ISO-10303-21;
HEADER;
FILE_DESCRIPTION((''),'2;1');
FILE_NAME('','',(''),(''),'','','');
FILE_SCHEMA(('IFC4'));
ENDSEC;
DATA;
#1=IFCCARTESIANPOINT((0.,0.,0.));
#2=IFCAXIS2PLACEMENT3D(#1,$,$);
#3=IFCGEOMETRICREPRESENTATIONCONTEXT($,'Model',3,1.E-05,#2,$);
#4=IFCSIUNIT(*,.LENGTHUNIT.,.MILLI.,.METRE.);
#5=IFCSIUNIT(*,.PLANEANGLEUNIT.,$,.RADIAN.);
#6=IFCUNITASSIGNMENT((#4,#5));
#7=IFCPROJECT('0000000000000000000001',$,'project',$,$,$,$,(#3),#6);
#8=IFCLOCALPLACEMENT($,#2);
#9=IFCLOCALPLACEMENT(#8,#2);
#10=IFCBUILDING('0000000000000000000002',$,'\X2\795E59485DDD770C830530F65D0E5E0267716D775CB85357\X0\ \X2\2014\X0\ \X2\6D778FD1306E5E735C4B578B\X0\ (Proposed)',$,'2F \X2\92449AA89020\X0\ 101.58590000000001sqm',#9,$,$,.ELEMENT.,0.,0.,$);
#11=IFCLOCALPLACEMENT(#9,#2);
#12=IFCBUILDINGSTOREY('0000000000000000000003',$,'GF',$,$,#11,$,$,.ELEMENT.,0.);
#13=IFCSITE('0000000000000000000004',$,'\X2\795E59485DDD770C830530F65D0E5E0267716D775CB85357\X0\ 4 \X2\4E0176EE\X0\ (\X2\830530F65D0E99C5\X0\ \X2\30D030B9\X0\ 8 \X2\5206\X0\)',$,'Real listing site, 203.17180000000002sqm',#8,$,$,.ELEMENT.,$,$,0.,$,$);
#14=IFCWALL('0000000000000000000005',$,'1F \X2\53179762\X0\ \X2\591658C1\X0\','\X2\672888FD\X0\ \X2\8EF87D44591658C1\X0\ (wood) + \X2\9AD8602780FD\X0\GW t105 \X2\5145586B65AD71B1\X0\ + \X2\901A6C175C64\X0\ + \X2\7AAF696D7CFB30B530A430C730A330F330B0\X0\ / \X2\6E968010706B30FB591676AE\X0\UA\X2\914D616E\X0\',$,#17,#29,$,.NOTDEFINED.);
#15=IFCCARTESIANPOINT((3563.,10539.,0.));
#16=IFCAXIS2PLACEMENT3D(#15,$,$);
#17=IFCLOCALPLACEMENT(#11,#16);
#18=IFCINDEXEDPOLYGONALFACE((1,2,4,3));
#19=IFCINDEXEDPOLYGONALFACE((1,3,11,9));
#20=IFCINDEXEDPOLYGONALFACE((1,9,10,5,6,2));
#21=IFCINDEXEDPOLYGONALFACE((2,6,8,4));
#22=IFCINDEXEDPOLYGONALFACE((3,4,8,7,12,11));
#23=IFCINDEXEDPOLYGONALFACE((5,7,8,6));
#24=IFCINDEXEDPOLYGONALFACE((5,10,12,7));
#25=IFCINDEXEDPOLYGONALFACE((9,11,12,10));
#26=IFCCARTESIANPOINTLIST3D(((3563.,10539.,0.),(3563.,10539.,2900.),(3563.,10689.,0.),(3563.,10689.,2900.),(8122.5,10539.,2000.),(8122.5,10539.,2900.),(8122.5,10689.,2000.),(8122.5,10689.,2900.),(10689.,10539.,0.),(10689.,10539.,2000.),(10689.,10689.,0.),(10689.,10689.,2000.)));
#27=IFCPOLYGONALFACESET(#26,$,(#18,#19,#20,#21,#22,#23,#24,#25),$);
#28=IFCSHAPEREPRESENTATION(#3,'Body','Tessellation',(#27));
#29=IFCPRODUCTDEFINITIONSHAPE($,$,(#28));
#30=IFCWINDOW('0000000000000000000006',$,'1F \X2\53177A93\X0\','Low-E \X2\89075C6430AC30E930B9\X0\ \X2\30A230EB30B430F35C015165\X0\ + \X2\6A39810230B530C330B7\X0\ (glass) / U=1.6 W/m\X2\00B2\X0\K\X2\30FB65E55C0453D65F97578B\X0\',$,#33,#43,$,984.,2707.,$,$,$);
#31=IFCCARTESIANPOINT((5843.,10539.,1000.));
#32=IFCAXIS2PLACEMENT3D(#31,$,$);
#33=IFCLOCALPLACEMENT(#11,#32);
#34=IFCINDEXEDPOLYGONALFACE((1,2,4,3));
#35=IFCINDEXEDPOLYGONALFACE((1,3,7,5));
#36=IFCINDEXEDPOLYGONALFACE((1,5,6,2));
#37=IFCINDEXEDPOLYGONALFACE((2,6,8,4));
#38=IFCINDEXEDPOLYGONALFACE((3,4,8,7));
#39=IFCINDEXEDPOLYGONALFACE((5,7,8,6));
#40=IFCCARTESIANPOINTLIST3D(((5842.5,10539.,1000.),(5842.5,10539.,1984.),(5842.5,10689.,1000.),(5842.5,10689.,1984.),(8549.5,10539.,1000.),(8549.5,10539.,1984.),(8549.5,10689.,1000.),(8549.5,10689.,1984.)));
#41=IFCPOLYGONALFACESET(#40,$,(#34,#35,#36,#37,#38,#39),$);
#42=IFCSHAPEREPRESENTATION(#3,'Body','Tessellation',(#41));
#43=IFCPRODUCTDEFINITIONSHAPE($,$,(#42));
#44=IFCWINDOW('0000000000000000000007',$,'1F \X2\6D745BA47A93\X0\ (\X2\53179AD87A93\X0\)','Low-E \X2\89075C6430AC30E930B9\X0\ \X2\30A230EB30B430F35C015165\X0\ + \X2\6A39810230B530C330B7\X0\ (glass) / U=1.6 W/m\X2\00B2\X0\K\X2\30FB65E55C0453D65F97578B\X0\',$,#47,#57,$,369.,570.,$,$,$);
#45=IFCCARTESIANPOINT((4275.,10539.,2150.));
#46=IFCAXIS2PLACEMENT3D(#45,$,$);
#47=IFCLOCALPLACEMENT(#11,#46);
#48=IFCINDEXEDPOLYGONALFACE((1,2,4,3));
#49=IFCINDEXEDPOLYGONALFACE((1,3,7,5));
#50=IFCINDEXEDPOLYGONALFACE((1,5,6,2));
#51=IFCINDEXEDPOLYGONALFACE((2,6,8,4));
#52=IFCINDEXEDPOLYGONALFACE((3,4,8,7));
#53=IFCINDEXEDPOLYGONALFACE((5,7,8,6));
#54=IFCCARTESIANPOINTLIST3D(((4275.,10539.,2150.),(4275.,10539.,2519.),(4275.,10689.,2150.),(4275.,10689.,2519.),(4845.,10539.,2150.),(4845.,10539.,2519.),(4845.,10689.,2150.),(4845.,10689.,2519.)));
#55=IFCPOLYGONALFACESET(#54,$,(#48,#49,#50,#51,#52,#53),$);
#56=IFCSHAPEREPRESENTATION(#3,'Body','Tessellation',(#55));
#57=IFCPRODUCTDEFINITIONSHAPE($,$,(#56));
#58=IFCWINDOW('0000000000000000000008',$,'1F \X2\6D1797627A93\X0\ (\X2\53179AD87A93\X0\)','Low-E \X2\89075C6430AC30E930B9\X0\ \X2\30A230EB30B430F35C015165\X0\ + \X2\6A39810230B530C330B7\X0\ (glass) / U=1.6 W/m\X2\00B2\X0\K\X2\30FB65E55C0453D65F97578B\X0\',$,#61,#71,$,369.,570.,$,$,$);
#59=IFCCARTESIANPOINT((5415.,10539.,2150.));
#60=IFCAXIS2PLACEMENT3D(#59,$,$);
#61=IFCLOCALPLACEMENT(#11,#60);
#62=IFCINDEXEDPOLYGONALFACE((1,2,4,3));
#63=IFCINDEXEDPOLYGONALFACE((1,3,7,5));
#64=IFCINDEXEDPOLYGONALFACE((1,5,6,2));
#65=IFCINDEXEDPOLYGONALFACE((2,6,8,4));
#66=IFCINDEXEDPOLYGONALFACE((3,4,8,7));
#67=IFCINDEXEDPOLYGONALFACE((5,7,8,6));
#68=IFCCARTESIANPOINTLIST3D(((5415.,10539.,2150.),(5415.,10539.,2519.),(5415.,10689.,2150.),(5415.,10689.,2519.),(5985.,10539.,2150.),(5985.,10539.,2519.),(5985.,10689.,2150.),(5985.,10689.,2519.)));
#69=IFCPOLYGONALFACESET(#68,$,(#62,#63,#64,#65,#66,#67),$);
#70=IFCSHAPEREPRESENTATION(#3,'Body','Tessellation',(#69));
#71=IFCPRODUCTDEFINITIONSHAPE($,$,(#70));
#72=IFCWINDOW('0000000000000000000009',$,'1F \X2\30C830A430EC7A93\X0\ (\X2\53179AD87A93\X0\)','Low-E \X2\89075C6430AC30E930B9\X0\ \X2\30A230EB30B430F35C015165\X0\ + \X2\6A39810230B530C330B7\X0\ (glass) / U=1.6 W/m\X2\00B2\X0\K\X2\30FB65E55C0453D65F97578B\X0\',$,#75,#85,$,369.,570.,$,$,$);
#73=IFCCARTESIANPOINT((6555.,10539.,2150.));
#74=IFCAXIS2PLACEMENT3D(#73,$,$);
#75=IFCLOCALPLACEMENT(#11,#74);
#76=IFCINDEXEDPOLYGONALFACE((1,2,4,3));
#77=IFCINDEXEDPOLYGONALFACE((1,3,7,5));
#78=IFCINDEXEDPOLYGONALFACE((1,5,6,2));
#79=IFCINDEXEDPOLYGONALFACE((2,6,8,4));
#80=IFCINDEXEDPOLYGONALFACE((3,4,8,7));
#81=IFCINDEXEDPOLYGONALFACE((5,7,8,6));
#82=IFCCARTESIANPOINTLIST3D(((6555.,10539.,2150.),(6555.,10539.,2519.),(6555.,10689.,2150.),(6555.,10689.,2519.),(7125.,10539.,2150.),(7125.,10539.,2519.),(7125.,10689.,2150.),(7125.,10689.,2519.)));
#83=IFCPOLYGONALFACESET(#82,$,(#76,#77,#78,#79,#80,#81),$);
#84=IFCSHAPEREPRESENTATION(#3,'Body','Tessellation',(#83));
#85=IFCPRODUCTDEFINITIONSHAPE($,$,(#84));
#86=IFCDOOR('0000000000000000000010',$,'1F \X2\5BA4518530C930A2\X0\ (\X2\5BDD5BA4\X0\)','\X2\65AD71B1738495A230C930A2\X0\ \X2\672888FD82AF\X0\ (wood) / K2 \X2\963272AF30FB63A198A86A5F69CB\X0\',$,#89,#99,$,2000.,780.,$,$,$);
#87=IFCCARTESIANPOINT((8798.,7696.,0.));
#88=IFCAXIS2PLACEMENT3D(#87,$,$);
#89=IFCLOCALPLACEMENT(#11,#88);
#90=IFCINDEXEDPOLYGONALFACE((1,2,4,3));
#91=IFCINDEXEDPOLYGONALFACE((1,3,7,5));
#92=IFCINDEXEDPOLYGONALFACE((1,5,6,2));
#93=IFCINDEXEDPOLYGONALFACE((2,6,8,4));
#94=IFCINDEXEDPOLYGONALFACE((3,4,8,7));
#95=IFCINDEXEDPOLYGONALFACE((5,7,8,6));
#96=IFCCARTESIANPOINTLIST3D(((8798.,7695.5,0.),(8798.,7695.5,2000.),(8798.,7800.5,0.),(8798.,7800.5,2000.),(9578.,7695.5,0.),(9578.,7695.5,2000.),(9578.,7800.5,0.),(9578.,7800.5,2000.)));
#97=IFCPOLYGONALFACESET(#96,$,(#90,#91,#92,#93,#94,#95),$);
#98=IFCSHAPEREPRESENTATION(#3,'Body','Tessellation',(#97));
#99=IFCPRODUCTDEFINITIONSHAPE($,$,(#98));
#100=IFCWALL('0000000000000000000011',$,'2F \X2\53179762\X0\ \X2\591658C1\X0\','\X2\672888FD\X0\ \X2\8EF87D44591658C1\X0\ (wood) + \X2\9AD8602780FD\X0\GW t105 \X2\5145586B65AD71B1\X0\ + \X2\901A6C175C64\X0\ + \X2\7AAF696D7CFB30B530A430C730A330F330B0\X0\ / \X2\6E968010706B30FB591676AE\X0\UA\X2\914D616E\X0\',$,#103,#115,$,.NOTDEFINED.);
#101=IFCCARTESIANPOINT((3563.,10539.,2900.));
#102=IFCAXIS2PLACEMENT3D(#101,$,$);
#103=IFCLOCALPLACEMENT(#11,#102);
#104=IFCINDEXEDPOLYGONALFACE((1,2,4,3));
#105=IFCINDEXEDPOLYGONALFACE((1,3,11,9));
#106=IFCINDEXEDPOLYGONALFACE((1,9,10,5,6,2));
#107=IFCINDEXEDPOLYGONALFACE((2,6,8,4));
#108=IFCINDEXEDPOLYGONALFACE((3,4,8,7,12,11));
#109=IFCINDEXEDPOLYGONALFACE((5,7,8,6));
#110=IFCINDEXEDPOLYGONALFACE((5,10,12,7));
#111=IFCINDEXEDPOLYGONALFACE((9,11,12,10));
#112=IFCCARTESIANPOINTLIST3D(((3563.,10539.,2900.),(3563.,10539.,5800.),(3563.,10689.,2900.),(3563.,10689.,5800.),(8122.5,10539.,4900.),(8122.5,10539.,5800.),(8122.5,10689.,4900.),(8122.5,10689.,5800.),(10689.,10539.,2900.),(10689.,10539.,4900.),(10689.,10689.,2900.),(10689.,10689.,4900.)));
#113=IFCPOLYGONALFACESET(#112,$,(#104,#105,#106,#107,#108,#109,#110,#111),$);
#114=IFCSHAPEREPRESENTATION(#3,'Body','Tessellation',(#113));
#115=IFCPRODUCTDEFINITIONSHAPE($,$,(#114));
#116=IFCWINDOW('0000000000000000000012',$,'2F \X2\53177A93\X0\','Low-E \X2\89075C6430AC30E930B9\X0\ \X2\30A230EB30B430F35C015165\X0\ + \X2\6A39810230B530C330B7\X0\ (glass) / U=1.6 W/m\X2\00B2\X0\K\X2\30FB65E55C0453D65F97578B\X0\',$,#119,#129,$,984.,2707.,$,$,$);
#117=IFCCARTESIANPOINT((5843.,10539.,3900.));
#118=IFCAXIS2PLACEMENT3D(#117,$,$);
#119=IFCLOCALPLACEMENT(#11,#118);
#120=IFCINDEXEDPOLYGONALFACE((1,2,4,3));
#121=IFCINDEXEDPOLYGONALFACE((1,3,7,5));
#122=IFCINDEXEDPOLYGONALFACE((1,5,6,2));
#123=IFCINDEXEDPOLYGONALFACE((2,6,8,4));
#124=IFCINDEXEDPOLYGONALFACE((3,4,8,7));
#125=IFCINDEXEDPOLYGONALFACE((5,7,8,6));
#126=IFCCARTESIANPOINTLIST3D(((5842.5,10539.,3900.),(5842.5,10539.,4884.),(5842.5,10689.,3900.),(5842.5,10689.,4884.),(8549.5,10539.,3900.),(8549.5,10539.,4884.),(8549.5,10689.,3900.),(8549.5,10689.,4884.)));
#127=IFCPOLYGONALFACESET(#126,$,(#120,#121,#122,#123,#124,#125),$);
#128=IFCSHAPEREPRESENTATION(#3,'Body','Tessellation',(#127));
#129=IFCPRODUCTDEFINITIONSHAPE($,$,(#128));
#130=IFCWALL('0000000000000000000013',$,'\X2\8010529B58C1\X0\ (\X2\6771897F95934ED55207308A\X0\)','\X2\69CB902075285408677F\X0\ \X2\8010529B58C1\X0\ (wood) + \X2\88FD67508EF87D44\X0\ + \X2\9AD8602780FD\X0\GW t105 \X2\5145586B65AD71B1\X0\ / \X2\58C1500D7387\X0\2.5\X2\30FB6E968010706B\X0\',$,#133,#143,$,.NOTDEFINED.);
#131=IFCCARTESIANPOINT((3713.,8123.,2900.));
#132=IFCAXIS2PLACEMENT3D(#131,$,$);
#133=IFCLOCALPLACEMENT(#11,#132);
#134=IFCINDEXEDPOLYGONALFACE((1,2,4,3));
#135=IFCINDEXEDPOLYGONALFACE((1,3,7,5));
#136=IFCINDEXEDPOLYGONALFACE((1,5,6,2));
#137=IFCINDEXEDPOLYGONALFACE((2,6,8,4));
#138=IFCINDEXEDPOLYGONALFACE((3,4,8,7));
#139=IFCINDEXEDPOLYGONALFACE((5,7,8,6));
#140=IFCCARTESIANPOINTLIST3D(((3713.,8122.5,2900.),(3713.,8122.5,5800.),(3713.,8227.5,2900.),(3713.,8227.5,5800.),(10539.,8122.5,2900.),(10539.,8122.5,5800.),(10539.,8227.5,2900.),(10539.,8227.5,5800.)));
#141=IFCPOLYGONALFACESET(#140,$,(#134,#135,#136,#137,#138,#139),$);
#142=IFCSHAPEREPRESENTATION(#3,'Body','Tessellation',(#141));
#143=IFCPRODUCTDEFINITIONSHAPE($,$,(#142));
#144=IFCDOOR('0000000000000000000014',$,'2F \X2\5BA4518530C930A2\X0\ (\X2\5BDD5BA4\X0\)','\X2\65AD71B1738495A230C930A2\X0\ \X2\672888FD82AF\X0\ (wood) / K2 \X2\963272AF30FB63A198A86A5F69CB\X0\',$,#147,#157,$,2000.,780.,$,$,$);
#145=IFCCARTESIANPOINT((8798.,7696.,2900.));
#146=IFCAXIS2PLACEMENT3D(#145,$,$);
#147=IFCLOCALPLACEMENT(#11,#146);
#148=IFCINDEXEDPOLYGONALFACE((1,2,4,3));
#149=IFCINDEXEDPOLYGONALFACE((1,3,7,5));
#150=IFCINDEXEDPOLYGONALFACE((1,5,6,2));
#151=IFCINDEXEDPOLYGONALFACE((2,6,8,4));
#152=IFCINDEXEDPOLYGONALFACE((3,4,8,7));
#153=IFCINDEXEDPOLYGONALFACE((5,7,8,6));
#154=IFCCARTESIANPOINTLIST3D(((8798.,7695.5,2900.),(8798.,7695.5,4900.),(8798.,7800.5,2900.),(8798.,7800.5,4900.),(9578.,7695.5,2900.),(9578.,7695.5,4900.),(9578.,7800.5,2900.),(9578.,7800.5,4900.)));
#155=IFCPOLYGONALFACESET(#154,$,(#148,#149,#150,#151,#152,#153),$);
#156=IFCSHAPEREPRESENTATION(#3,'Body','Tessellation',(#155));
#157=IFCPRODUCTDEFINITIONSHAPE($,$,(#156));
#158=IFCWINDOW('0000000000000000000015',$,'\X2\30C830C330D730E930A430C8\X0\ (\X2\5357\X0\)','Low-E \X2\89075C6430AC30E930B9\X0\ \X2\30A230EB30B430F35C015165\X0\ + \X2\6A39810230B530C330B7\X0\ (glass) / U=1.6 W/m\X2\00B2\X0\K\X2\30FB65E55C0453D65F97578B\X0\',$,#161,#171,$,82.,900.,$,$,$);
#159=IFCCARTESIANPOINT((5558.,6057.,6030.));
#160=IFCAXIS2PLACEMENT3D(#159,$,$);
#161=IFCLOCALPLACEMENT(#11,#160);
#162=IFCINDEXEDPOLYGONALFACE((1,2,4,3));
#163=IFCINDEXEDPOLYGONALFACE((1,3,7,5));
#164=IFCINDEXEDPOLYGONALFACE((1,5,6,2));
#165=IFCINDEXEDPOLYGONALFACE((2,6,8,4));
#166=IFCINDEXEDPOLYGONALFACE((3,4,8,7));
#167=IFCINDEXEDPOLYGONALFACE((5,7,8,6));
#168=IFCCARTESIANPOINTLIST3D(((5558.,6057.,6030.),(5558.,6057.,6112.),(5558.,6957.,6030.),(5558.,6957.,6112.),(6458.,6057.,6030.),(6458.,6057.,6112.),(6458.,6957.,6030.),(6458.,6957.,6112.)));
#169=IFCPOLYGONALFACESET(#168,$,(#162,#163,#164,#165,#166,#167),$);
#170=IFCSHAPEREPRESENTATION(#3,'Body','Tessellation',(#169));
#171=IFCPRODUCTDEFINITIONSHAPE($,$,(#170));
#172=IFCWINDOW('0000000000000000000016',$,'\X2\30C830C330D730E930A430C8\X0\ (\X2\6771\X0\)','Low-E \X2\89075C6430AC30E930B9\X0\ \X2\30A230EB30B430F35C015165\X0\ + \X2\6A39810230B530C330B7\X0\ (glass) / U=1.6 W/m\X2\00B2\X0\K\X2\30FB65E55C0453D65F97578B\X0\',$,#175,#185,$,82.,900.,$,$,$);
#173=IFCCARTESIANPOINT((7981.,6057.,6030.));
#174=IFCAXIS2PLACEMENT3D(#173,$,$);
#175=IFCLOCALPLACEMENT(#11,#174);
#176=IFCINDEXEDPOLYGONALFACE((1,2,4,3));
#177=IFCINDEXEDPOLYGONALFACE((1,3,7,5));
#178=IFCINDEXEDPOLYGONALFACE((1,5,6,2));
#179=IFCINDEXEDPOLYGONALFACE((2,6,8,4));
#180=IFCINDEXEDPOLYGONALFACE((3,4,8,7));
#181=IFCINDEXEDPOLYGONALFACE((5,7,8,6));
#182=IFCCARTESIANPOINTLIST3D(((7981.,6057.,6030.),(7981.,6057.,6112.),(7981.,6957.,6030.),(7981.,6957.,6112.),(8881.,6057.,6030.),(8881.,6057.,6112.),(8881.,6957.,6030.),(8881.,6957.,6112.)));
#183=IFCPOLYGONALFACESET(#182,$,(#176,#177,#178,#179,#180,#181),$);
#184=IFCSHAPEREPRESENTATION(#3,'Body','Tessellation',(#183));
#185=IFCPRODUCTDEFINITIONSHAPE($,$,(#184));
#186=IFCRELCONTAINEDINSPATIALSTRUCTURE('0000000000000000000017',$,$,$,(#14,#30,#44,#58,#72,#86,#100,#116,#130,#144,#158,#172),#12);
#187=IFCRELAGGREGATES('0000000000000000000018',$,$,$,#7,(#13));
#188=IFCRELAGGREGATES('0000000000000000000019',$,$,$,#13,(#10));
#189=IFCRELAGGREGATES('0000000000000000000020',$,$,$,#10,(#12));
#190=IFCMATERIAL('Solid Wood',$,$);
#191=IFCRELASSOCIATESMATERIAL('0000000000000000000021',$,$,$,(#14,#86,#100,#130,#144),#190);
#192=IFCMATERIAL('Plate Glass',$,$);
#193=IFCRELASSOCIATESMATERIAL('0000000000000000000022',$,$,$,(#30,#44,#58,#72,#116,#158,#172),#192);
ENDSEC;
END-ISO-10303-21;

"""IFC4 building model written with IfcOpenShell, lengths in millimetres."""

from ifc_helpers import new_model, si_unit, frame, frame_2d, origin, place, context, project, spatial, rectangle, extrude, material, element, fill, save


model = new_model("IFC4")

# Units and contexts
model_context = context("Model", 3, precision=1e-05, world=origin())
ifc_project = project(units=[si_unit("LENGTHUNIT", "METRE", prefix="MILLI"), si_unit("PLANEANGLEUNIT", "RADIAN")], contexts=[model_context])

# Site, building, storey
site_placement = place(None, origin())
site = spatial("IfcSite", under=ifc_project, at=site_placement, Name="神奈川県茅ヶ崎市東海岸南 4 丁目 (茅ヶ崎駅 バス 8 分)", ObjectType="Real listing site, 203.17180000000002sqm", CompositionType="ELEMENT", RefElevation=0.0)
building_placement = place(site_placement, origin())
building = spatial("IfcBuilding", under=site, at=building_placement, Name="神奈川県茅ヶ崎市東海岸南 — 海近の平屋型 (Proposed)", ObjectType="2F 鉄骨造 101.58590000000001sqm", CompositionType="ELEMENT", ElevationOfRefHeight=0.0, ElevationOfTerrain=0.0)
storey_placement = place(building_placement, origin())
storey = spatial("IfcBuildingStorey", under=building, at=storey_placement, Name="GF", CompositionType="ELEMENT", Elevation=0.0)

# Wall, openings, windows
ifc_material_1 = material(Name="Solid Wood")
wall_1_placement = place(storey_placement, frame((3563.0, 10539.0, 0.0)))
wall_1 = element("IfcWall", 1, at=wall_1_placement, inside=storey, material=ifc_material_1, Name="1F 北面 外壁", Description="木製 軸組外壁 (wood) + 高性能GW t105 充填断熱 + 通気層 + 窯業系サイディング / 準耐火・外皮UA配慮", PredefinedType="NOTDEFINED", context=model_context, shape_type="SweptSolid", body=[
    extrude(rectangle(XDim=7126.0, YDim=150.0, at=frame_2d((3563.0, 75.0))), frame((3563.0, 10539.0, 0.0)), (0.0, 0.0, 1.0), 2900.0),
])
opening_1_placement = place(storey_placement, frame((5843.0, 10539.0, 1000.0)))
opening_1 = element("IfcOpeningElement", 2, at=opening_1_placement, cuts=wall_1, PredefinedType="NOTDEFINED", context=model_context, shape_type="SweptSolid", body=[
    extrude(rectangle(XDim=2707.0, YDim=150.0, at=frame_2d((1353.0, 75.0))), frame((5843.0, 10539.0, 1000.0)), (0.0, 0.0, 1.0), 984.0),
])
opening_2_placement = place(storey_placement, frame((4275.0, 10539.0, 2150.0)))
opening_2 = element("IfcOpeningElement", 3, at=opening_2_placement, cuts=wall_1, PredefinedType="NOTDEFINED", context=model_context, shape_type="SweptSolid", body=[
    extrude(rectangle(XDim=570.0, YDim=150.0, at=frame_2d((285.0, 75.0))), frame((4275.0, 10539.0, 2150.0)), (0.0, 0.0, 1.0), 369.0),
])
opening_3_placement = place(storey_placement, frame((5415.0, 10539.0, 2150.0)))
opening_3 = element("IfcOpeningElement", 4, at=opening_3_placement, cuts=wall_1, PredefinedType="NOTDEFINED", context=model_context, shape_type="SweptSolid", body=[
    extrude(rectangle(XDim=570.0, YDim=150.0, at=frame_2d((285.0, 75.0))), frame((5415.0, 10539.0, 2150.0)), (0.0, 0.0, 1.0), 369.0),
])
opening_4_placement = place(storey_placement, frame((6555.0, 10539.0, 2150.0)))
opening_4 = element("IfcOpeningElement", 5, at=opening_4_placement, cuts=wall_1, PredefinedType="NOTDEFINED", context=model_context, shape_type="SweptSolid", body=[
    extrude(rectangle(XDim=570.0, YDim=150.0, at=frame_2d((285.0, 75.0))), frame((6555.0, 10539.0, 2150.0)), (0.0, 0.0, 1.0), 369.0),
])
ifc_material_2 = material(Name="Plate Glass")
window_1_placement = place(storey_placement, frame((5843.0, 10539.0, 1000.0)))
window_1 = element("IfcWindow", 6, at=window_1_placement, inside=storey, material=ifc_material_2, Name="1F 北窓", Description="Low-E 複層ガラス アルゴン封入 + 樹脂サッシ (glass) / U=1.6 W/m²K・日射取得型", OverallHeight=984.0, OverallWidth=2707.0, context=model_context, shape_type="SweptSolid", body=[
    extrude(rectangle(XDim=2707.0, YDim=150.0, at=frame_2d((1353.0, 75.0))), frame((5843.0, 10539.0, 1000.0)), (0.0, 0.0, 1.0), 984.0),
])
fill(opening_1, window_1)
window_2_placement = place(storey_placement, frame((4275.0, 10539.0, 2150.0)))
window_2 = element("IfcWindow", 7, at=window_2_placement, inside=storey, material=ifc_material_2, Name="1F 浴室窓 (北高窓)", Description="Low-E 複層ガラス アルゴン封入 + 樹脂サッシ (glass) / U=1.6 W/m²K・日射取得型", OverallHeight=369.0, OverallWidth=570.0, context=model_context, shape_type="SweptSolid", body=[
    extrude(rectangle(XDim=570.0, YDim=150.0, at=frame_2d((285.0, 75.0))), frame((4275.0, 10539.0, 2150.0)), (0.0, 0.0, 1.0), 369.0),
])
fill(opening_2, window_2)
window_3_placement = place(storey_placement, frame((5415.0, 10539.0, 2150.0)))
window_3 = element("IfcWindow", 8, at=window_3_placement, inside=storey, material=ifc_material_2, Name="1F 洗面窓 (北高窓)", Description="Low-E 複層ガラス アルゴン封入 + 樹脂サッシ (glass) / U=1.6 W/m²K・日射取得型", OverallHeight=369.0, OverallWidth=570.0, context=model_context, shape_type="SweptSolid", body=[
    extrude(rectangle(XDim=570.0, YDim=150.0, at=frame_2d((285.0, 75.0))), frame((5415.0, 10539.0, 2150.0)), (0.0, 0.0, 1.0), 369.0),
])
fill(opening_3, window_3)
window_4_placement = place(storey_placement, frame((6555.0, 10539.0, 2150.0)))
window_4 = element("IfcWindow", 9, at=window_4_placement, inside=storey, material=ifc_material_2, Name="1F トイレ窓 (北高窓)", Description="Low-E 複層ガラス アルゴン封入 + 樹脂サッシ (glass) / U=1.6 W/m²K・日射取得型", OverallHeight=369.0, OverallWidth=570.0, context=model_context, shape_type="SweptSolid", body=[
    extrude(rectangle(XDim=570.0, YDim=150.0, at=frame_2d((285.0, 75.0))), frame((6555.0, 10539.0, 2150.0)), (0.0, 0.0, 1.0), 369.0),
])
fill(opening_4, window_4)

# Door
door_1_placement = place(storey_placement, frame((8798.0, 7696.0, 0.0)))
element("IfcDoor", 10, at=door_1_placement, inside=storey, material=ifc_material_1, Name="1F 室内ドア (寝室)", Description="断熱玄関ドア 木製芯 (wood) / K2 防犯・採風機構", OverallHeight=2000.0, OverallWidth=780.0, context=model_context, shape_type="SweptSolid", body=[
    extrude(rectangle(XDim=780.0, YDim=105.0, at=frame_2d((390.0, 52.0))), frame((8798.0, 7696.0, 0.0)), (0.0, 0.0, 1.0), 2000.0),
])

# Wall, opening, window
wall_2_placement = place(storey_placement, frame((3563.0, 10539.0, 2900.0)))
wall_2 = element("IfcWall", 11, at=wall_2_placement, inside=storey, material=ifc_material_1, Name="2F 北面 外壁", Description="木製 軸組外壁 (wood) + 高性能GW t105 充填断熱 + 通気層 + 窯業系サイディング / 準耐火・外皮UA配慮", PredefinedType="NOTDEFINED", context=model_context, shape_type="SweptSolid", body=[
    extrude(rectangle(XDim=7126.0, YDim=150.0, at=frame_2d((3563.0, 75.0))), frame((3563.0, 10539.0, 2900.0)), (0.0, 0.0, 1.0), 2900.0),
])
opening_5_placement = place(storey_placement, frame((5843.0, 10539.0, 3900.0)))
opening_5 = element("IfcOpeningElement", 12, at=opening_5_placement, cuts=wall_2, PredefinedType="NOTDEFINED", context=model_context, shape_type="SweptSolid", body=[
    extrude(rectangle(XDim=2707.0, YDim=150.0, at=frame_2d((1353.0, 75.0))), frame((5843.0, 10539.0, 3900.0)), (0.0, 0.0, 1.0), 984.0),
])
window_5_placement = place(storey_placement, frame((5843.0, 10539.0, 3900.0)))
window_5 = element("IfcWindow", 13, at=window_5_placement, inside=storey, material=ifc_material_2, Name="2F 北窓", Description="Low-E 複層ガラス アルゴン封入 + 樹脂サッシ (glass) / U=1.6 W/m²K・日射取得型", OverallHeight=984.0, OverallWidth=2707.0, context=model_context, shape_type="SweptSolid", body=[
    extrude(rectangle(XDim=2707.0, YDim=150.0, at=frame_2d((1353.0, 75.0))), frame((5843.0, 10539.0, 3900.0)), (0.0, 0.0, 1.0), 984.0),
])
fill(opening_5, window_5)

# Wall
wall_3_placement = place(storey_placement, frame((3713.0, 8123.0, 2900.0)))
element("IfcWall", 14, at=wall_3_placement, inside=storey, material=ifc_material_1, Name="耐力壁 (東西間仕切り)", Description="構造用合板 耐力壁 (wood) + 製材軸組 + 高性能GW t105 充填断熱 / 壁倍率2.5・準耐火", PredefinedType="NOTDEFINED", context=model_context, shape_type="SweptSolid", body=[
    extrude(rectangle(XDim=6826.0, YDim=105.0, at=frame_2d((3413.0, 52.0))), frame((3713.0, 8123.0, 2900.0)), (0.0, 0.0, 1.0), 2900.0),
])

# Door
door_2_placement = place(storey_placement, frame((8798.0, 7696.0, 2900.0)))
element("IfcDoor", 15, at=door_2_placement, inside=storey, material=ifc_material_1, Name="2F 室内ドア (寝室)", Description="断熱玄関ドア 木製芯 (wood) / K2 防犯・採風機構", OverallHeight=2000.0, OverallWidth=780.0, context=model_context, shape_type="SweptSolid", body=[
    extrude(rectangle(XDim=780.0, YDim=105.0, at=frame_2d((390.0, 52.0))), frame((8798.0, 7696.0, 2900.0)), (0.0, 0.0, 1.0), 2000.0),
])

# Windows
window_6_placement = place(storey_placement, frame((5558.0, 6057.0, 6030.0)))
element("IfcWindow", 16, at=window_6_placement, inside=storey, material=ifc_material_2, Name="トップライト (南)", Description="Low-E 複層ガラス アルゴン封入 + 樹脂サッシ (glass) / U=1.6 W/m²K・日射取得型", OverallHeight=82.0, OverallWidth=900.0, context=model_context, shape_type="SweptSolid", body=[
    extrude(rectangle(XDim=900.0, YDim=900.0, at=frame_2d((450.0, 450.0))), frame((5558.0, 6057.0, 6030.0)), (0.0, 0.0, 1.0), 82.0),
])
window_7_placement = place(storey_placement, frame((7981.0, 6057.0, 6030.0)))
element("IfcWindow", 17, at=window_7_placement, inside=storey, material=ifc_material_2, Name="トップライト (東)", Description="Low-E 複層ガラス アルゴン封入 + 樹脂サッシ (glass) / U=1.6 W/m²K・日射取得型", OverallHeight=82.0, OverallWidth=900.0, context=model_context, shape_type="SweptSolid", body=[
    extrude(rectangle(XDim=900.0, YDim=900.0, at=frame_2d((450.0, 450.0))), frame((7981.0, 6057.0, 6030.0)), (0.0, 0.0, 1.0), 82.0),
])

save(model, "model.ifc")
